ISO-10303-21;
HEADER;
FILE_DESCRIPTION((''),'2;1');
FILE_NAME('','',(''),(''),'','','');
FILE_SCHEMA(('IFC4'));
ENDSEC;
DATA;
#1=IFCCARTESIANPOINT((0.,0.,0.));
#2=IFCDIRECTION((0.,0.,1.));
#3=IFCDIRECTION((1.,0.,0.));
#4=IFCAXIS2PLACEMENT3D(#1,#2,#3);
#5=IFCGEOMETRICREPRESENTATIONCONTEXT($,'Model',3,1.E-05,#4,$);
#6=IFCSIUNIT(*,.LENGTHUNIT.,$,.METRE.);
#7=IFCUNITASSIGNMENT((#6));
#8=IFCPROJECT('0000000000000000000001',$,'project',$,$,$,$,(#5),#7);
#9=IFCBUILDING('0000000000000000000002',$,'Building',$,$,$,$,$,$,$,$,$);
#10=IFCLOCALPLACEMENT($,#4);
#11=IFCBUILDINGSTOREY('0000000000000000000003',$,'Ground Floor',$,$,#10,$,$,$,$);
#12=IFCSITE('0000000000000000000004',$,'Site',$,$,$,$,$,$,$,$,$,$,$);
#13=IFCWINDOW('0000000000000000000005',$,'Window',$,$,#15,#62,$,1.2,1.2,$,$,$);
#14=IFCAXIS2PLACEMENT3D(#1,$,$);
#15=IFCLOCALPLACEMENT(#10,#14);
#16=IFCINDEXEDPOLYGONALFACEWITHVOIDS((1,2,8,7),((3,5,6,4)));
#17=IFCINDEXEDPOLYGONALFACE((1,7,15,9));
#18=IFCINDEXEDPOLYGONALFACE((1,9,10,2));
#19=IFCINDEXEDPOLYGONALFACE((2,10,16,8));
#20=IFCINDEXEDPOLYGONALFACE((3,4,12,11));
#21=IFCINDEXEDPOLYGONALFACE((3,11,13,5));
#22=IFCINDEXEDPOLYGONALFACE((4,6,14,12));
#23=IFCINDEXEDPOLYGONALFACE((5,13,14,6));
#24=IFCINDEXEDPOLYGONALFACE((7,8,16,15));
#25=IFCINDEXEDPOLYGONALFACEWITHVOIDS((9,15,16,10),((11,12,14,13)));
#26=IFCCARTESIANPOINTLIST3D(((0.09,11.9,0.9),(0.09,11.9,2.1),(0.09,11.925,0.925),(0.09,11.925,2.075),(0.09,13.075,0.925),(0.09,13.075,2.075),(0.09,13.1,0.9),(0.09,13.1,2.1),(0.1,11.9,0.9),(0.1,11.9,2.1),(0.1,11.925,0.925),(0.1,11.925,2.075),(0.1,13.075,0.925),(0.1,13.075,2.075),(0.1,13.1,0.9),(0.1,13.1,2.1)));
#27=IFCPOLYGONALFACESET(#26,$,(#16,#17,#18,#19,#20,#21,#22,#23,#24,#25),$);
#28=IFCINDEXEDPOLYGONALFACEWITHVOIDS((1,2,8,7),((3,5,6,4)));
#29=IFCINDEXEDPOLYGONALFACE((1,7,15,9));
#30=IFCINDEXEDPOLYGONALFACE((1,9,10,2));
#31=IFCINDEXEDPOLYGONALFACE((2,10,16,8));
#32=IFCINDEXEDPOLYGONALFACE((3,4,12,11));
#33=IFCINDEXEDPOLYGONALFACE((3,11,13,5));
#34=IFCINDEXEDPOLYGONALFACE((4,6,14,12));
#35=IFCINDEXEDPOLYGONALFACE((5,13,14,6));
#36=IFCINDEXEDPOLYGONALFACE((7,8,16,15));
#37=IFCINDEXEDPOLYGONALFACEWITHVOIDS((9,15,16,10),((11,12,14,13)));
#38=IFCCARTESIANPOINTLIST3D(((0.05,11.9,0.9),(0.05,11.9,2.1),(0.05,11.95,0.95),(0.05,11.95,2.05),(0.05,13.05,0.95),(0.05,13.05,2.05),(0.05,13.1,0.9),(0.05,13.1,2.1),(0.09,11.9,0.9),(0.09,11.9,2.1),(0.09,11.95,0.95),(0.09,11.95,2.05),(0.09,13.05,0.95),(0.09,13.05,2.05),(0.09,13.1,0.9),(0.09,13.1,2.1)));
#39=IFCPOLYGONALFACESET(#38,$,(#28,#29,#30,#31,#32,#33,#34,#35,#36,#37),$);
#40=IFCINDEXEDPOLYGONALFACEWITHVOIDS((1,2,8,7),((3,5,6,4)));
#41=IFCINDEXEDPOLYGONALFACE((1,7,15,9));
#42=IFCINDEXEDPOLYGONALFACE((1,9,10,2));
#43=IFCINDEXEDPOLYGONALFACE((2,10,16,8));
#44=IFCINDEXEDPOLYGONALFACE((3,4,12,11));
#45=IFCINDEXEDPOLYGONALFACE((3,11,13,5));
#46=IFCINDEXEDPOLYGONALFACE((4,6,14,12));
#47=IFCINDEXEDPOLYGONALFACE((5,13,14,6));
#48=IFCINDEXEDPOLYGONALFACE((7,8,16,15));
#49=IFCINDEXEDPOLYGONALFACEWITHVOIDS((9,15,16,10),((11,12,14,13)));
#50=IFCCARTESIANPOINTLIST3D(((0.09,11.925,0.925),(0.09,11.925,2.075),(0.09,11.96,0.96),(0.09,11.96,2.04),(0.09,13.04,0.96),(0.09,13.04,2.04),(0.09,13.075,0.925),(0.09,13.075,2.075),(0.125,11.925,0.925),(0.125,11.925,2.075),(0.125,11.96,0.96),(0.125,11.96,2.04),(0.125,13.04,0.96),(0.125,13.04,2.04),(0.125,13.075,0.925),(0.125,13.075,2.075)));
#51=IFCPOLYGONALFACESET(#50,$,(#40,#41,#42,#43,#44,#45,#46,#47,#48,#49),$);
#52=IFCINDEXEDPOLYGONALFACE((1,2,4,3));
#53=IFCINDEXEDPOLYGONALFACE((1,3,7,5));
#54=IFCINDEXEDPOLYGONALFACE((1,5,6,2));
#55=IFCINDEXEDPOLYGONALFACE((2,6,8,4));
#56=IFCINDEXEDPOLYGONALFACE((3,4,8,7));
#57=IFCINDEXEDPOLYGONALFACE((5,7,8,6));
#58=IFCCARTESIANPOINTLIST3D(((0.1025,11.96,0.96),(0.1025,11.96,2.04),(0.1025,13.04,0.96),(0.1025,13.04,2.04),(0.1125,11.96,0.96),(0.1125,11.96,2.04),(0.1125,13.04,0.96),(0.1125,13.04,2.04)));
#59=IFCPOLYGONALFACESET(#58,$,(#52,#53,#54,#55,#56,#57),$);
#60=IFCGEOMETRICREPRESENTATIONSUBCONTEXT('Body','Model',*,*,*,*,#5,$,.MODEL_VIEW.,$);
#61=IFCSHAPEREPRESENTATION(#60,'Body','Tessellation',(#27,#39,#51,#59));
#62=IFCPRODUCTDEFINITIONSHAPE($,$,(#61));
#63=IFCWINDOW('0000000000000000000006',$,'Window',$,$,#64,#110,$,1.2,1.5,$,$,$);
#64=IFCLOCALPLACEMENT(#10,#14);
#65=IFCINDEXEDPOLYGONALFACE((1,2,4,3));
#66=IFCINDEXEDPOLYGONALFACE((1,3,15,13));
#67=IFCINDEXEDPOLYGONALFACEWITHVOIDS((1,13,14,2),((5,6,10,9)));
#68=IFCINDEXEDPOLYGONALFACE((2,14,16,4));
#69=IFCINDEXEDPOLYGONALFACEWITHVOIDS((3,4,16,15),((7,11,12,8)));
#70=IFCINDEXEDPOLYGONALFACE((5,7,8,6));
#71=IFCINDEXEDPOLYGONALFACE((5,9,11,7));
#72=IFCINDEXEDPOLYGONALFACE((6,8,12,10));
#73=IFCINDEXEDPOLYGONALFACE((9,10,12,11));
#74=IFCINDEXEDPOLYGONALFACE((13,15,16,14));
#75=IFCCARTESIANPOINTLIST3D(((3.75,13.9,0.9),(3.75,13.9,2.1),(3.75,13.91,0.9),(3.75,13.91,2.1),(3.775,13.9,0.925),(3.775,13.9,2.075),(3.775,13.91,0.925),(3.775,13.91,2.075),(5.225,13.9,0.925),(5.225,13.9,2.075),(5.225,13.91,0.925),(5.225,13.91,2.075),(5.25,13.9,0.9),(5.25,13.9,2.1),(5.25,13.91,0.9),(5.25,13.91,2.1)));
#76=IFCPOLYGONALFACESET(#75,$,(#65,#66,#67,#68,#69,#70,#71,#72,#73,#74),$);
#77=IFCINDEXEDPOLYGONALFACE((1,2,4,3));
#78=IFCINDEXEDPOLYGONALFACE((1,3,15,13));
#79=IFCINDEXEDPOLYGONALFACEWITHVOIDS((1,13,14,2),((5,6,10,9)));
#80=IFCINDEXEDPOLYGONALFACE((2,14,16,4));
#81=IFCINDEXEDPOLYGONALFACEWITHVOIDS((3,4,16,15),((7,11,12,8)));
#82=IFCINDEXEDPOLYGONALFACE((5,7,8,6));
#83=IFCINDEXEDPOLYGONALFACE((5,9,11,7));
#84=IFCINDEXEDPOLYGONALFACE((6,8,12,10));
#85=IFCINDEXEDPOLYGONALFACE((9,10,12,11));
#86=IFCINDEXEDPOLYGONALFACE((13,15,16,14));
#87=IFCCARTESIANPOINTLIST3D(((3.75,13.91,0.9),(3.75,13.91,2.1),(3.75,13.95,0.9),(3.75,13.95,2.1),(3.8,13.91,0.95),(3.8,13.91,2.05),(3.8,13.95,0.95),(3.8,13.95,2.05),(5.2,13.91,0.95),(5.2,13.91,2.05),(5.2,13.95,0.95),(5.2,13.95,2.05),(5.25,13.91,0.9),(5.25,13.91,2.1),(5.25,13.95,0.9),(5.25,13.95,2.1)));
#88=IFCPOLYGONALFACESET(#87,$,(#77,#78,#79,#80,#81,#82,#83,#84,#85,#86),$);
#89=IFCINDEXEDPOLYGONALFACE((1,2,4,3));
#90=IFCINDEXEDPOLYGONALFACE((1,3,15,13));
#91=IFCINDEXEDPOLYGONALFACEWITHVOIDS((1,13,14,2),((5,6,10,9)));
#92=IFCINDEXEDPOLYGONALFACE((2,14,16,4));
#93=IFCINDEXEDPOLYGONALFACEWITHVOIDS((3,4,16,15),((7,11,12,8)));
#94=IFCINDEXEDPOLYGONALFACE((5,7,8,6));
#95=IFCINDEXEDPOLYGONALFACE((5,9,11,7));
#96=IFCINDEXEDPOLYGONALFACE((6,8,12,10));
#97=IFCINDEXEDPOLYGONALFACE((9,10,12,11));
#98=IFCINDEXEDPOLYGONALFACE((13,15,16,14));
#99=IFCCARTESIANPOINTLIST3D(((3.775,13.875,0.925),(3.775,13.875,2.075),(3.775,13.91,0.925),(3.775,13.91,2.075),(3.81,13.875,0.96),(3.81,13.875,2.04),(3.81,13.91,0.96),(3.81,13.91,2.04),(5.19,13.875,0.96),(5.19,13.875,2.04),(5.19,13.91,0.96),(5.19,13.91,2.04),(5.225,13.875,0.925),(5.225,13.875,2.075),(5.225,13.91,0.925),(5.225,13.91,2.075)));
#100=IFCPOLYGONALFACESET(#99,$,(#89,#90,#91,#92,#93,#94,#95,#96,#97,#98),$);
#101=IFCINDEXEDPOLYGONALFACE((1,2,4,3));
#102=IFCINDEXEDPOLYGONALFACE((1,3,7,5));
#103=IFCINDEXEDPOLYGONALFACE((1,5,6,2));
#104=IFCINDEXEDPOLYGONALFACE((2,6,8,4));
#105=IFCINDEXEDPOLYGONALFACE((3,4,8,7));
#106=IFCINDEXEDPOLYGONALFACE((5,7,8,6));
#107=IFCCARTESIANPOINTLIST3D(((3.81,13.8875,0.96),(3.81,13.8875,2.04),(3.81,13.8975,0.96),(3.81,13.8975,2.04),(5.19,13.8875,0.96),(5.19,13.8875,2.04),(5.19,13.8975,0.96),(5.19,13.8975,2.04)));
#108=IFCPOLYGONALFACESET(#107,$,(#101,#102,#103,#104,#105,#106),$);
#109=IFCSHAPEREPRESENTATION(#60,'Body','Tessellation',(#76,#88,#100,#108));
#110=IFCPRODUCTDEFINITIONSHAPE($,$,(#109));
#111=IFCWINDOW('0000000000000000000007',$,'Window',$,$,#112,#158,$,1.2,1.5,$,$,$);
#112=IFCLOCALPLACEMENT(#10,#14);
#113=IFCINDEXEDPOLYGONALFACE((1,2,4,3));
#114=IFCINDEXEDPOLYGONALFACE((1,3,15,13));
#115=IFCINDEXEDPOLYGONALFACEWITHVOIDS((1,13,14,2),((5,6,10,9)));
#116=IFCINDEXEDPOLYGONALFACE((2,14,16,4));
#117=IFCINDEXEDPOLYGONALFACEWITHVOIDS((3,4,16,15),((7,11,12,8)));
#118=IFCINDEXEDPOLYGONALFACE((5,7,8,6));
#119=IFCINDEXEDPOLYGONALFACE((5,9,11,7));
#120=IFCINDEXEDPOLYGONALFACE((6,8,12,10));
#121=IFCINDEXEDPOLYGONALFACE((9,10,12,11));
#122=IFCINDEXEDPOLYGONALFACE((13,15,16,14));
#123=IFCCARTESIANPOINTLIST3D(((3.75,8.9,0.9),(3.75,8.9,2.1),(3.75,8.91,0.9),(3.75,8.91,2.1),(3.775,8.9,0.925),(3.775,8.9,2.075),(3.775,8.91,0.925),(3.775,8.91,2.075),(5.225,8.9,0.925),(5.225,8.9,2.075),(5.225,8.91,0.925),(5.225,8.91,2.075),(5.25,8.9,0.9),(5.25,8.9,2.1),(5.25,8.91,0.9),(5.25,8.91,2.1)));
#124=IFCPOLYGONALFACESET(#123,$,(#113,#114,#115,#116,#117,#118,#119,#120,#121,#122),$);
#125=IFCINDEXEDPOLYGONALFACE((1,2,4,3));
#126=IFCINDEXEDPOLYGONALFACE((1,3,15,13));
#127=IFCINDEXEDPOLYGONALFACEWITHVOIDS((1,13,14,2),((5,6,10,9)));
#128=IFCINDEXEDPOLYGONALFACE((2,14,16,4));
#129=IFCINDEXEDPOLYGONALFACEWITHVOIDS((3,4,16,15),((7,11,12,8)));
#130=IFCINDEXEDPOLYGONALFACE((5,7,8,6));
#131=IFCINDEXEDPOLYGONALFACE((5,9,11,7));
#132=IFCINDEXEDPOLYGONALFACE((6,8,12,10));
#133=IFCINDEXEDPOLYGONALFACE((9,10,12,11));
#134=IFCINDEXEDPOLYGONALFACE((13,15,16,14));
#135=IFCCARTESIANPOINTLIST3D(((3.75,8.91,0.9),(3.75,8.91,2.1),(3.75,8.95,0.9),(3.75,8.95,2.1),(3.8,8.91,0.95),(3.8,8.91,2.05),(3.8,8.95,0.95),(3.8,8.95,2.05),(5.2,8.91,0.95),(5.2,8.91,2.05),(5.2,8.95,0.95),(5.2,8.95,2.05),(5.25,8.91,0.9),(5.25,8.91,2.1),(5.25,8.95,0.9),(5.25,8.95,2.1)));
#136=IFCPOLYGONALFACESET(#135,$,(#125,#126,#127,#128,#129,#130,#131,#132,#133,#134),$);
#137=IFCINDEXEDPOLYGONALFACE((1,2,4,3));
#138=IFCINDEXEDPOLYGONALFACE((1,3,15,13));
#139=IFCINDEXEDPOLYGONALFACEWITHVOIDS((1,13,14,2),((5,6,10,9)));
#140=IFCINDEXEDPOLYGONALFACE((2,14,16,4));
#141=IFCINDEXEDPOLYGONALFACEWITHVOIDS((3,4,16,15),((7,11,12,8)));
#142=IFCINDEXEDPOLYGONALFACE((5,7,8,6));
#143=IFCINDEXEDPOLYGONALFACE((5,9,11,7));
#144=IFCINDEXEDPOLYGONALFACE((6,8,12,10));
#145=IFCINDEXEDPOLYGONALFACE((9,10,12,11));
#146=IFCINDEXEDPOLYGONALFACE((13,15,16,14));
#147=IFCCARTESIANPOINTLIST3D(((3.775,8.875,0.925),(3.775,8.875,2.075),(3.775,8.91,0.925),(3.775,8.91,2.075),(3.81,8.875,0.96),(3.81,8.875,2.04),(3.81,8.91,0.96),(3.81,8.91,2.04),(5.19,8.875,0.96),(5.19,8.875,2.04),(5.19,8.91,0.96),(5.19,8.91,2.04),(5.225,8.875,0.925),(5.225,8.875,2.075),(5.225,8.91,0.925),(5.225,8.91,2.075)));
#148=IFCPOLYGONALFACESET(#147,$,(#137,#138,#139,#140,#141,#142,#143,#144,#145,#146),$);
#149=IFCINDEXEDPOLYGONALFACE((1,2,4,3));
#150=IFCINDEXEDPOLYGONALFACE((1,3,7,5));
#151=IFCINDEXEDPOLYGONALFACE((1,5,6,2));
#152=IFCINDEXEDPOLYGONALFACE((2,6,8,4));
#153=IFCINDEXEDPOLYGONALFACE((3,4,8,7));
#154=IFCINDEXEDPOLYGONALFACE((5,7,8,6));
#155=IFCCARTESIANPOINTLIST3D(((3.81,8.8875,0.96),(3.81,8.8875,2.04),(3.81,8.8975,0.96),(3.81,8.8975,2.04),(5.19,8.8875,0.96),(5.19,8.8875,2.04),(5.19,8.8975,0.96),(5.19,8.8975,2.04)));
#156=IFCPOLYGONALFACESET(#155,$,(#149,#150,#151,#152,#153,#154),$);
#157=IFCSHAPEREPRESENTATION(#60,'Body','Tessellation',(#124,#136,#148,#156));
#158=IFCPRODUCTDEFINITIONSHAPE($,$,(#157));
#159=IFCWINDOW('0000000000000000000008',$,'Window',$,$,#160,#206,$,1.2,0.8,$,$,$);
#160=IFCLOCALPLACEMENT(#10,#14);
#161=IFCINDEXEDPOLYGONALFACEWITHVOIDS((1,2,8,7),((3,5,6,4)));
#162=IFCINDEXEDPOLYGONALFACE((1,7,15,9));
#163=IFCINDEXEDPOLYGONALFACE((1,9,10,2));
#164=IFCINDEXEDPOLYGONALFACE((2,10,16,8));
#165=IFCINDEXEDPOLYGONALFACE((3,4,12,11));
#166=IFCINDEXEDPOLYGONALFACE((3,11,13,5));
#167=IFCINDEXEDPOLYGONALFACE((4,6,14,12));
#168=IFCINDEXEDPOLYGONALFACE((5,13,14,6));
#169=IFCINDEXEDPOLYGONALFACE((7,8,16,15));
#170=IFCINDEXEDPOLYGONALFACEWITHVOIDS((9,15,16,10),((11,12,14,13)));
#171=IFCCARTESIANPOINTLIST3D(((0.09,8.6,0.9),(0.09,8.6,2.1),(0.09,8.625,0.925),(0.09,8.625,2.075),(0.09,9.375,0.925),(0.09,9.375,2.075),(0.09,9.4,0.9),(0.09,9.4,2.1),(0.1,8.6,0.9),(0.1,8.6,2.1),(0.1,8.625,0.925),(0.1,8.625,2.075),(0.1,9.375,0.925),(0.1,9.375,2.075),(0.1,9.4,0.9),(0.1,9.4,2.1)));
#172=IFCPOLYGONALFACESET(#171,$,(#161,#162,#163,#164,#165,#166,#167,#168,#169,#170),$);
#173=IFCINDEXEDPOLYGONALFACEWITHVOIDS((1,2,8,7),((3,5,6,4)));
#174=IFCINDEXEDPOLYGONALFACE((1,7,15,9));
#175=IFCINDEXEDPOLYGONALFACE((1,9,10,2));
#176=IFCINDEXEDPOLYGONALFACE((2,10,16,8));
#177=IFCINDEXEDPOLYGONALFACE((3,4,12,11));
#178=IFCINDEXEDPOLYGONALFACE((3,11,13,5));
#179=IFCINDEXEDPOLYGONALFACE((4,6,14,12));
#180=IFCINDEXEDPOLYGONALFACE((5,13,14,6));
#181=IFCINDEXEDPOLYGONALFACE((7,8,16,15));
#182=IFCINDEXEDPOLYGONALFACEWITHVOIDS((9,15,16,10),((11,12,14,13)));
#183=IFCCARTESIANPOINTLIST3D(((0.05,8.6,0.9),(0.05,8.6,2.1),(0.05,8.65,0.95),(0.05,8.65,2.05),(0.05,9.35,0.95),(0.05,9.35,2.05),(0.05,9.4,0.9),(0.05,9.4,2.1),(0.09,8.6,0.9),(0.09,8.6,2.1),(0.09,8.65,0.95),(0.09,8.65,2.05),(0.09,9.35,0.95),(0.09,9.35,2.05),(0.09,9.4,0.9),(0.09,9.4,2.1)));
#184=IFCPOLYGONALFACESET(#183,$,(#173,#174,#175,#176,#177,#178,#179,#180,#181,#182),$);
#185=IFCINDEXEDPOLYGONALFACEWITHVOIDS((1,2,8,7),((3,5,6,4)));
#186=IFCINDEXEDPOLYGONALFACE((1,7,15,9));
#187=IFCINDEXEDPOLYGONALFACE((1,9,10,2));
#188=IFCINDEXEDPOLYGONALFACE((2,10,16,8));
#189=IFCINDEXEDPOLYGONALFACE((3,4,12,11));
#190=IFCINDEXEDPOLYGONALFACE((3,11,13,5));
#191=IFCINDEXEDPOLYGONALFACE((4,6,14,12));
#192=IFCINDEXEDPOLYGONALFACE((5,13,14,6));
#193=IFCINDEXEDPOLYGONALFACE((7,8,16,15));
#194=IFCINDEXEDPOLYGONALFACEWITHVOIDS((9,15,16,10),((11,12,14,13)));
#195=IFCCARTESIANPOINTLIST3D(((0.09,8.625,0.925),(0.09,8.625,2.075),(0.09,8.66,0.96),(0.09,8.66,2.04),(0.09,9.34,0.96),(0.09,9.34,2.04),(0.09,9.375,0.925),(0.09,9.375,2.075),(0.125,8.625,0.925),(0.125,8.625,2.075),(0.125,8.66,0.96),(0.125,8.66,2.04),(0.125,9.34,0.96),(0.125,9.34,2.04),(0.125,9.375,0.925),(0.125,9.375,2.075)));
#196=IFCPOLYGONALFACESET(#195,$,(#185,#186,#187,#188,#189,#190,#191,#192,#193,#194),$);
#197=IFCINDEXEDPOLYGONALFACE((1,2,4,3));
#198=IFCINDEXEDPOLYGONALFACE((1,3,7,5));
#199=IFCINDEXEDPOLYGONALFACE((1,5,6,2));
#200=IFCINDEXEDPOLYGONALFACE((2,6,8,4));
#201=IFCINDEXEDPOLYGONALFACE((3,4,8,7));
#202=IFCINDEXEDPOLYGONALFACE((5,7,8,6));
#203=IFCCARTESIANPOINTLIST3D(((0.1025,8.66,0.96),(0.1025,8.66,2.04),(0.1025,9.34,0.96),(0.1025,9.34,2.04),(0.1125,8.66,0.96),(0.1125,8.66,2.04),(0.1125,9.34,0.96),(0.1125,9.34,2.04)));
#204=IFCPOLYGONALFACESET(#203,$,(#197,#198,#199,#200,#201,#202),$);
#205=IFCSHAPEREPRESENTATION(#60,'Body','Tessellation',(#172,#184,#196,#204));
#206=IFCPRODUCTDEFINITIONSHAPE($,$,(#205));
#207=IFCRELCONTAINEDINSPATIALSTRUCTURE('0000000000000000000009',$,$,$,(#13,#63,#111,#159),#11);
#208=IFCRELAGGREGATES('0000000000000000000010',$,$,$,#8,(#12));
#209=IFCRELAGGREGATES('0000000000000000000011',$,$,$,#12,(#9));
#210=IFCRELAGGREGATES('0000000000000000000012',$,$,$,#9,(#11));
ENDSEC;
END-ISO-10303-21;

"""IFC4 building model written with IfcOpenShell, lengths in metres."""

from ifc_helpers import new_model, si_unit, frame, origin_with_axes, place, context, subcontext, project, spatial, line, indexed_curve, outline, extrude, element, save


model = new_model("IFC4")

# Units and contexts
model_context = context("Model", 3, precision=1e-05, world=origin_with_axes())
body_context = subcontext(model_context, "Body", "Model", "MODEL_VIEW")
ifc_project = project(units=[si_unit("LENGTHUNIT", "METRE")], contexts=[model_context])

# Site, building, storey
site = spatial("IfcSite", under=ifc_project, Name="Site")
building = spatial("IfcBuilding", under=site, Name="Building")
storey_placement = place(None, origin_with_axes())
storey = spatial("IfcBuildingStorey", under=building, at=storey_placement, Name="Ground Floor")

# Windows
for number, where, z_axis, x_axis, name in (
    (1, (0.0, 13.1, 0.9), (0.0, 0.0, 1.0), (0.0, -1.0, 0.0), "Window"),
):
    element("IfcWindow", number, at=place(storey_placement, frame(where, z_axis=z_axis, x_axis=x_axis)), inside=storey, Name=name, OverallHeight=1.2, OverallWidth=1.2, context=body_context, shape_type="SweptSolid", body=[
        extrude(outline(indexed_curve([(0.0, 0.0), (1.2, 0.0), (1.2, 1.2), (0.0, 1.2)], segments=[line(1, 2, 3, 4, 1)]), holes=[indexed_curve([(0.025, 0.025), (1.175, 0.025), (1.175, 1.175), (0.025, 1.175)], segments=[line(1, 2, 3, 4, 1)])]), frame((0.0, 0.09, 0.0), z_axis=(0.0, -1.0, 0.0), x_axis=(1.0, 0.0, 0.0)), (0.0, 0.0, -1.0), 0.01),
        extrude(outline(indexed_curve([(0.0, 0.0), (1.2, 0.0), (1.2, 1.2), (0.0, 1.2)], segments=[line(1, 2, 3, 4, 1)]), holes=[indexed_curve([(0.05, 0.05), (1.15, 0.05), (1.15, 1.15), (0.05, 1.15)], segments=[line(1, 2, 3, 4, 1)])]), frame((0.0, 0.05, 0.0), z_axis=(0.0, -1.0, 0.0), x_axis=(1.0, 0.0, 0.0)), (0.0, 0.0, -1.0), 0.04),
        extrude(outline(indexed_curve([(0.0, 0.0), (1.15, 0.0), (1.15, 1.15), (0.0, 1.15)], segments=[line(1, 2, 3, 4, 1)]), holes=[indexed_curve([(0.035, 0.035), (1.115, 0.035), (1.115, 1.115), (0.035, 1.115)], segments=[line(1, 2, 3, 4, 1)])]), frame((0.025, 0.09, 0.025), z_axis=(0.0, -1.0, 0.0), x_axis=(1.0, 0.0, 0.0)), (0.0, 0.0, -1.0), 0.035),
        extrude(outline(indexed_curve([(0.035, 0.035), (1.115, 0.035), (1.115, 1.115), (0.035, 1.115)], segments=[line(1, 2, 3, 4, 1)])), frame((0.025, 0.1025, 0.025), z_axis=(0.0, -1.0, 0.0), x_axis=(1.0, 0.0, 0.0)), (0.0, 0.0, -1.0), 0.01),
    ])
for number, where, z_axis, x_axis, name in (
    (2, (5.25, 14.0, 0.9), (0.0, 0.0, 1.0), (-1.0, 0.0, 0.0), "Window"),
    (3, (5.25, 9.0, 0.9), (0.0, 0.0, 1.0), (-1.0, 0.0, 0.0), "Window"),
):
    element("IfcWindow", number, at=place(storey_placement, frame(where, z_axis=z_axis, x_axis=x_axis)), inside=storey, Name=name, OverallHeight=1.2, OverallWidth=1.5, context=body_context, shape_type="SweptSolid", body=[
        extrude(outline(indexed_curve([(0.0, 0.0), (1.5, 0.0), (1.5, 1.2), (0.0, 1.2)], segments=[line(1, 2, 3, 4, 1)]), holes=[indexed_curve([(0.025, 0.025), (1.475, 0.025), (1.475, 1.175), (0.025, 1.175)], segments=[line(1, 2, 3, 4, 1)])]), frame((0.0, 0.09, 0.0), z_axis=(0.0, -1.0, 0.0), x_axis=(1.0, 0.0, 0.0)), (0.0, 0.0, -1.0), 0.01),
        extrude(outline(indexed_curve([(0.0, 0.0), (1.5, 0.0), (1.5, 1.2), (0.0, 1.2)], segments=[line(1, 2, 3, 4, 1)]), holes=[indexed_curve([(0.05, 0.05), (1.45, 0.05), (1.45, 1.15), (0.05, 1.15)], segments=[line(1, 2, 3, 4, 1)])]), frame((0.0, 0.05, 0.0), z_axis=(0.0, -1.0, 0.0), x_axis=(1.0, 0.0, 0.0)), (0.0, 0.0, -1.0), 0.04),
        extrude(outline(indexed_curve([(0.0, 0.0), (1.45, 0.0), (1.45, 1.15), (0.0, 1.15)], segments=[line(1, 2, 3, 4, 1)]), holes=[indexed_curve([(0.035, 0.035), (1.415, 0.035), (1.415, 1.115), (0.035, 1.115)], segments=[line(1, 2, 3, 4, 1)])]), frame((0.025, 0.09, 0.025), z_axis=(0.0, -1.0, 0.0), x_axis=(1.0, 0.0, 0.0)), (0.0, 0.0, -1.0), 0.035),
        extrude(outline(indexed_curve([(0.035, 0.035), (1.415, 0.035), (1.415, 1.115), (0.035, 1.115)], segments=[line(1, 2, 3, 4, 1)])), frame((0.025, 0.1025, 0.025), z_axis=(0.0, -1.0, 0.0), x_axis=(1.0, 0.0, 0.0)), (0.0, 0.0, -1.0), 0.01),
    ])
window_1_placement = place(storey_placement, frame((0.0, 9.4, 0.9), z_axis=(0.0, 0.0, 1.0), x_axis=(0.0, -1.0, 0.0)))
element("IfcWindow", 4, at=window_1_placement, inside=storey, Name="Window", OverallHeight=1.2, OverallWidth=0.8, context=body_context, shape_type="SweptSolid", body=[
    extrude(outline(indexed_curve([(0.0, 0.0), (0.8, 0.0), (0.8, 1.2), (0.0, 1.2)], segments=[line(1, 2, 3, 4, 1)]), holes=[indexed_curve([(0.025, 0.025), (0.775, 0.025), (0.775, 1.175), (0.025, 1.175)], segments=[line(1, 2, 3, 4, 1)])]), frame((0.0, 0.09, 0.0), z_axis=(0.0, -1.0, 0.0), x_axis=(1.0, 0.0, 0.0)), (0.0, 0.0, -1.0), 0.01),
    extrude(outline(indexed_curve([(0.0, 0.0), (0.8, 0.0), (0.8, 1.2), (0.0, 1.2)], segments=[line(1, 2, 3, 4, 1)]), holes=[indexed_curve([(0.05, 0.05), (0.75, 0.05), (0.75, 1.15), (0.05, 1.15)], segments=[line(1, 2, 3, 4, 1)])]), frame((0.0, 0.05, 0.0), z_axis=(0.0, -1.0, 0.0), x_axis=(1.0, 0.0, 0.0)), (0.0, 0.0, -1.0), 0.04),
    extrude(outline(indexed_curve([(0.0, 0.0), (0.75, 0.0), (0.75, 1.15), (0.0, 1.15)], segments=[line(1, 2, 3, 4, 1)]), holes=[indexed_curve([(0.035, 0.035), (0.715, 0.035), (0.715, 1.115), (0.035, 1.115)], segments=[line(1, 2, 3, 4, 1)])]), frame((0.025, 0.09, 0.025), z_axis=(0.0, -1.0, 0.0), x_axis=(1.0, 0.0, 0.0)), (0.0, 0.0, -1.0), 0.035),
    extrude(outline(indexed_curve([(0.035, 0.035), (0.715, 0.035), (0.715, 1.115), (0.035, 1.115)], segments=[line(1, 2, 3, 4, 1)])), frame((0.025, 0.1025, 0.025), z_axis=(0.0, -1.0, 0.0), x_axis=(1.0, 0.0, 0.0)), (0.0, 0.0, -1.0), 0.01),
])

save(model, "model.ifc")
